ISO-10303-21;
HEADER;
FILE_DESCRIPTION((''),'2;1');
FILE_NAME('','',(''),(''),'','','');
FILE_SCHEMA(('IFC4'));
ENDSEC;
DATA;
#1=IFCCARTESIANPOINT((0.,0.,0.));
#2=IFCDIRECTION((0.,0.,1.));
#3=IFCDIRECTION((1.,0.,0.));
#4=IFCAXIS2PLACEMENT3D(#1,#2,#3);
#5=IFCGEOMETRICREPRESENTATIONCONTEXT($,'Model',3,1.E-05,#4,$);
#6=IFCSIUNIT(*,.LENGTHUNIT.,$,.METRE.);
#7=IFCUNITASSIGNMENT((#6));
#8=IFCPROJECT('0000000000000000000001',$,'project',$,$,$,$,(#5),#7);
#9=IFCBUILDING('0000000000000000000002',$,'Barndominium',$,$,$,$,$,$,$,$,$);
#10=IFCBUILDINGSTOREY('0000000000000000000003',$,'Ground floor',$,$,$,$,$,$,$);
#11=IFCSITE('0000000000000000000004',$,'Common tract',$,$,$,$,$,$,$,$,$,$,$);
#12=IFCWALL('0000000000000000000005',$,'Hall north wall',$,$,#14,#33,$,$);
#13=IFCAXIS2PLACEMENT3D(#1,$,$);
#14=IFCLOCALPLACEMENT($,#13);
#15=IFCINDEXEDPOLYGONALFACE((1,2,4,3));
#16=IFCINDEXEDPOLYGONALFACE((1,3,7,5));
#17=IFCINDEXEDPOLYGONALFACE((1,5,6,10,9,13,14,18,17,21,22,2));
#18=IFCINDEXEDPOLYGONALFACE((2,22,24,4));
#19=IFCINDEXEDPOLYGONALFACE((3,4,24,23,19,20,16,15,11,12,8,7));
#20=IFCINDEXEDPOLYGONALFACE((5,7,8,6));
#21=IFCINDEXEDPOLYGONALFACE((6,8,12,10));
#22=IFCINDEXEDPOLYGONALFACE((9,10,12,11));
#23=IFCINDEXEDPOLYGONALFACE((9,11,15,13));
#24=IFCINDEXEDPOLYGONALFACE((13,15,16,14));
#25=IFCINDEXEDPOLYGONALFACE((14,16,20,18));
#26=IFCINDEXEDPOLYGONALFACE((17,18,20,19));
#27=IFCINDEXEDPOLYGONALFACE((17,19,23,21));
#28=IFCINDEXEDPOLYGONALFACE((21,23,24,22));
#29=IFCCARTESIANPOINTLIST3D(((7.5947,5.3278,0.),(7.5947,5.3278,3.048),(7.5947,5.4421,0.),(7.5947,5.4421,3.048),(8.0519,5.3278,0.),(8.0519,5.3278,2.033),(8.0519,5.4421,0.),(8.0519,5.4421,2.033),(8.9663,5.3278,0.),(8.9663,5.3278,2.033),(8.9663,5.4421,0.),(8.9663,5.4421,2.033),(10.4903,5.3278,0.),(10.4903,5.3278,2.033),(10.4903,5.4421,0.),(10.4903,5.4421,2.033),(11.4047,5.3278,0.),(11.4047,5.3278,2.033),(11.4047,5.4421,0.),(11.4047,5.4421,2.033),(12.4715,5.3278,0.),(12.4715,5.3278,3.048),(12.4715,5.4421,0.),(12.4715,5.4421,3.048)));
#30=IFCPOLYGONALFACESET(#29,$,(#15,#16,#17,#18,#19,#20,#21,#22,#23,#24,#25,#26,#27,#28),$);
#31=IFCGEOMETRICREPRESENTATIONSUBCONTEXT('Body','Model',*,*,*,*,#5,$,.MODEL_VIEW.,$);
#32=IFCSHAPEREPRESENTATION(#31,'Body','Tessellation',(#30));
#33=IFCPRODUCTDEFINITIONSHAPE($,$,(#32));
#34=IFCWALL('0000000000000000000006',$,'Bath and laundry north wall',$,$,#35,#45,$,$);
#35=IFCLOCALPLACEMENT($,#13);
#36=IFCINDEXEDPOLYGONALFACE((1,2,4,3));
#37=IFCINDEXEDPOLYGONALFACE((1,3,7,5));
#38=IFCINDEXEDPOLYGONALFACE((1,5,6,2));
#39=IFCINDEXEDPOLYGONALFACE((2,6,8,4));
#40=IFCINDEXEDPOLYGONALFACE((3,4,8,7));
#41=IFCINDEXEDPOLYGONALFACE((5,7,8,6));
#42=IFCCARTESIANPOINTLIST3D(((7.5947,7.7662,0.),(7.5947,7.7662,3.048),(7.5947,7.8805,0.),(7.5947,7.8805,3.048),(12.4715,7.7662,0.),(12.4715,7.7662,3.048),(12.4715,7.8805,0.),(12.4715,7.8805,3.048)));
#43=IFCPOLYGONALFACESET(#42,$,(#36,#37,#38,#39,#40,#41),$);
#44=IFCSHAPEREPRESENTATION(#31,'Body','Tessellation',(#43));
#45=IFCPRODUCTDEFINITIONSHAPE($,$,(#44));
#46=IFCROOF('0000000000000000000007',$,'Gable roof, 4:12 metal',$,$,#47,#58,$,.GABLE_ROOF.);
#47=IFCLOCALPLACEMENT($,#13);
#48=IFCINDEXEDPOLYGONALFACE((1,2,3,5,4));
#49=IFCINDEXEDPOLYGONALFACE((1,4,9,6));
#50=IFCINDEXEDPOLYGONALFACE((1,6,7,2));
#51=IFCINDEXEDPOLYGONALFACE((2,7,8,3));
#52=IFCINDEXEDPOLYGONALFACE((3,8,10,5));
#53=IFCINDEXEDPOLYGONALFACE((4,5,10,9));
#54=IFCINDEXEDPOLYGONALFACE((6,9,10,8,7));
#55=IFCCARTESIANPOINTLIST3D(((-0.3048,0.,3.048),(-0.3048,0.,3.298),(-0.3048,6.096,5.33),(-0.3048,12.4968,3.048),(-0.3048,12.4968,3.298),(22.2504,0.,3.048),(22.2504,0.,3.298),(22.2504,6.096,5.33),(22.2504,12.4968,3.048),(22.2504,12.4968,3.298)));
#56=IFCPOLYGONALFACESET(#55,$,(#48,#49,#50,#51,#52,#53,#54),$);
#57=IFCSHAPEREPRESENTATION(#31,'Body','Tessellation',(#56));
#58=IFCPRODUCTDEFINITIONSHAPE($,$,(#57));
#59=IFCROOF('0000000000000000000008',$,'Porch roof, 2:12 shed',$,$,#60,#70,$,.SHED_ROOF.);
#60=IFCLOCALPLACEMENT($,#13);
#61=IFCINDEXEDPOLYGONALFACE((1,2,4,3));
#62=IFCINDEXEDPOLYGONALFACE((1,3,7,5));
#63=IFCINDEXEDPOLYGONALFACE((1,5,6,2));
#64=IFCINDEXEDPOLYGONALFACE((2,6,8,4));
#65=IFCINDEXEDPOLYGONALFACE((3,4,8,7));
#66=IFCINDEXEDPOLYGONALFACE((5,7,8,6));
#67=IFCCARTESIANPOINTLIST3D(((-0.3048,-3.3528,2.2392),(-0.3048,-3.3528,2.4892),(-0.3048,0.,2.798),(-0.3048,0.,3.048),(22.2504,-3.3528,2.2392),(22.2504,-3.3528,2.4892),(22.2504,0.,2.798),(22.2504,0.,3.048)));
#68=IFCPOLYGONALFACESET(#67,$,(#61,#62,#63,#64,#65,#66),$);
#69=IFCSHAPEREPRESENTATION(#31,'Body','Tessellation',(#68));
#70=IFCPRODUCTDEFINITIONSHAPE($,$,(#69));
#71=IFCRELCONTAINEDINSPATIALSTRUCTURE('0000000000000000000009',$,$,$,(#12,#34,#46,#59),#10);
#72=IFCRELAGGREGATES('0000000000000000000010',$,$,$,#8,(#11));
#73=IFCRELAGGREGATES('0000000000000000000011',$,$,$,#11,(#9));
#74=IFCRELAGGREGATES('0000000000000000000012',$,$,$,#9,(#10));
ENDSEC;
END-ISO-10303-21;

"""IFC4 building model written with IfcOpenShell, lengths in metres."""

from ifc_helpers import new_model, si_unit, frame, origin_with_axes, place, context, subcontext, project, spatial, polyline, indexed_curve, rectangle, outline, extrude, element, save


model = new_model("IFC4")

# Units and contexts
model_context = context("Model", 3, precision=1e-05, world=origin_with_axes())
body_context = subcontext(model_context, "Body", "Model", "MODEL_VIEW")
ifc_project = project(units=[si_unit("LENGTHUNIT", "METRE")], contexts=[model_context])

# Site, building, storey
site = spatial("IfcSite", under=ifc_project, Name="Common tract")
building = spatial("IfcBuilding", under=site, Name="Barndominium")
storey = spatial("IfcBuildingStorey", under=building, Name="Ground floor")

# Wall, openings
wall_1_placement = place(None, frame((7.5947, 5.3278, 0.0), z_axis=(0.0, 0.0, 1.0), x_axis=(1.0, 0.0, 0.0)))
wall_1 = element("IfcWall", 1, at=wall_1_placement, inside=storey, Name="Hall north wall", context=body_context, shape_type="SweptSolid", body=[
    extrude(outline(indexed_curve([(0.0, 0.0), (0.0, 0.1143), (4.8768, 0.1143), (4.8768, 0.0), (0.0, 0.0)], self_intersect=False)), origin_with_axes(), (0.0, 0.0, 1.0), 3.048),
])
opening_1_placement = place(wall_1_placement, frame((0.9144, 0.0572, 0.0), z_axis=(0.0, 0.0, 1.0), x_axis=(1.0, 0.0, 0.0)))
element("IfcOpeningElement", 2, at=opening_1_placement, cuts=wall_1, context=body_context, shape_type="SweptSolid", body=[
    extrude(rectangle(XDim=0.9144, YDim=0.3033), origin_with_axes(), (0.0, 0.0, 1.0), 2.033),
])
opening_2_placement = place(wall_1_placement, frame((3.3528, 0.0572, 0.0), z_axis=(0.0, 0.0, 1.0), x_axis=(1.0, 0.0, 0.0)))
element("IfcOpeningElement", 3, at=opening_2_placement, cuts=wall_1, context=body_context, shape_type="SweptSolid", body=[
    extrude(rectangle(XDim=0.9144, YDim=0.3033), origin_with_axes(), (0.0, 0.0, 1.0), 2.033),
])

# Wall
wall_2_placement = place(None, frame((7.5947, 7.7662, 0.0), z_axis=(0.0, 0.0, 1.0), x_axis=(1.0, 0.0, 0.0)))
element("IfcWall", 4, at=wall_2_placement, inside=storey, Name="Bath and laundry north wall", context=body_context, shape_type="SweptSolid", body=[
    extrude(outline(indexed_curve([(0.0, 0.0), (0.0, 0.1143), (4.8768, 0.1143), (4.8768, 0.0), (0.0, 0.0)], self_intersect=False)), origin_with_axes(), (0.0, 0.0, 1.0), 3.048),
])

# Roofs
roof_1_placement = place(None, frame((-0.3048, 0.0, 0.0), z_axis=(1.0, 0.0, 0.0), x_axis=(0.0, 1.0, 0.0)))
element("IfcRoof", 5, at=roof_1_placement, inside=storey, Name="Gable roof, 4:12 metal", PredefinedType="GABLE_ROOF", context=body_context, shape_type="SweptSolid", body=[
    extrude(outline(polyline([(0.0, 3.048), (12.4968, 3.048), (12.4968, 3.298), (6.096, 5.33), (0.0, 3.298), (0.0, 3.048)])), origin_with_axes(), (0.0, 0.0, 1.0), 22.5552),
])
roof_2_placement = place(None, frame((-0.3048, 0.0, 0.0), z_axis=(1.0, 0.0, 0.0), x_axis=(0.0, 1.0, 0.0)))
element("IfcRoof", 6, at=roof_2_placement, inside=storey, Name="Porch roof, 2:12 shed", PredefinedType="SHED_ROOF", context=body_context, shape_type="SweptSolid", body=[
    extrude(outline(polyline([(0.0, 2.798), (-3.3528, 2.2392), (-3.3528, 2.4892), (0.0, 3.048), (0.0, 2.798)])), origin_with_axes(), (0.0, 0.0, 1.0), 22.5552),
])

save(model, "model.ifc")
